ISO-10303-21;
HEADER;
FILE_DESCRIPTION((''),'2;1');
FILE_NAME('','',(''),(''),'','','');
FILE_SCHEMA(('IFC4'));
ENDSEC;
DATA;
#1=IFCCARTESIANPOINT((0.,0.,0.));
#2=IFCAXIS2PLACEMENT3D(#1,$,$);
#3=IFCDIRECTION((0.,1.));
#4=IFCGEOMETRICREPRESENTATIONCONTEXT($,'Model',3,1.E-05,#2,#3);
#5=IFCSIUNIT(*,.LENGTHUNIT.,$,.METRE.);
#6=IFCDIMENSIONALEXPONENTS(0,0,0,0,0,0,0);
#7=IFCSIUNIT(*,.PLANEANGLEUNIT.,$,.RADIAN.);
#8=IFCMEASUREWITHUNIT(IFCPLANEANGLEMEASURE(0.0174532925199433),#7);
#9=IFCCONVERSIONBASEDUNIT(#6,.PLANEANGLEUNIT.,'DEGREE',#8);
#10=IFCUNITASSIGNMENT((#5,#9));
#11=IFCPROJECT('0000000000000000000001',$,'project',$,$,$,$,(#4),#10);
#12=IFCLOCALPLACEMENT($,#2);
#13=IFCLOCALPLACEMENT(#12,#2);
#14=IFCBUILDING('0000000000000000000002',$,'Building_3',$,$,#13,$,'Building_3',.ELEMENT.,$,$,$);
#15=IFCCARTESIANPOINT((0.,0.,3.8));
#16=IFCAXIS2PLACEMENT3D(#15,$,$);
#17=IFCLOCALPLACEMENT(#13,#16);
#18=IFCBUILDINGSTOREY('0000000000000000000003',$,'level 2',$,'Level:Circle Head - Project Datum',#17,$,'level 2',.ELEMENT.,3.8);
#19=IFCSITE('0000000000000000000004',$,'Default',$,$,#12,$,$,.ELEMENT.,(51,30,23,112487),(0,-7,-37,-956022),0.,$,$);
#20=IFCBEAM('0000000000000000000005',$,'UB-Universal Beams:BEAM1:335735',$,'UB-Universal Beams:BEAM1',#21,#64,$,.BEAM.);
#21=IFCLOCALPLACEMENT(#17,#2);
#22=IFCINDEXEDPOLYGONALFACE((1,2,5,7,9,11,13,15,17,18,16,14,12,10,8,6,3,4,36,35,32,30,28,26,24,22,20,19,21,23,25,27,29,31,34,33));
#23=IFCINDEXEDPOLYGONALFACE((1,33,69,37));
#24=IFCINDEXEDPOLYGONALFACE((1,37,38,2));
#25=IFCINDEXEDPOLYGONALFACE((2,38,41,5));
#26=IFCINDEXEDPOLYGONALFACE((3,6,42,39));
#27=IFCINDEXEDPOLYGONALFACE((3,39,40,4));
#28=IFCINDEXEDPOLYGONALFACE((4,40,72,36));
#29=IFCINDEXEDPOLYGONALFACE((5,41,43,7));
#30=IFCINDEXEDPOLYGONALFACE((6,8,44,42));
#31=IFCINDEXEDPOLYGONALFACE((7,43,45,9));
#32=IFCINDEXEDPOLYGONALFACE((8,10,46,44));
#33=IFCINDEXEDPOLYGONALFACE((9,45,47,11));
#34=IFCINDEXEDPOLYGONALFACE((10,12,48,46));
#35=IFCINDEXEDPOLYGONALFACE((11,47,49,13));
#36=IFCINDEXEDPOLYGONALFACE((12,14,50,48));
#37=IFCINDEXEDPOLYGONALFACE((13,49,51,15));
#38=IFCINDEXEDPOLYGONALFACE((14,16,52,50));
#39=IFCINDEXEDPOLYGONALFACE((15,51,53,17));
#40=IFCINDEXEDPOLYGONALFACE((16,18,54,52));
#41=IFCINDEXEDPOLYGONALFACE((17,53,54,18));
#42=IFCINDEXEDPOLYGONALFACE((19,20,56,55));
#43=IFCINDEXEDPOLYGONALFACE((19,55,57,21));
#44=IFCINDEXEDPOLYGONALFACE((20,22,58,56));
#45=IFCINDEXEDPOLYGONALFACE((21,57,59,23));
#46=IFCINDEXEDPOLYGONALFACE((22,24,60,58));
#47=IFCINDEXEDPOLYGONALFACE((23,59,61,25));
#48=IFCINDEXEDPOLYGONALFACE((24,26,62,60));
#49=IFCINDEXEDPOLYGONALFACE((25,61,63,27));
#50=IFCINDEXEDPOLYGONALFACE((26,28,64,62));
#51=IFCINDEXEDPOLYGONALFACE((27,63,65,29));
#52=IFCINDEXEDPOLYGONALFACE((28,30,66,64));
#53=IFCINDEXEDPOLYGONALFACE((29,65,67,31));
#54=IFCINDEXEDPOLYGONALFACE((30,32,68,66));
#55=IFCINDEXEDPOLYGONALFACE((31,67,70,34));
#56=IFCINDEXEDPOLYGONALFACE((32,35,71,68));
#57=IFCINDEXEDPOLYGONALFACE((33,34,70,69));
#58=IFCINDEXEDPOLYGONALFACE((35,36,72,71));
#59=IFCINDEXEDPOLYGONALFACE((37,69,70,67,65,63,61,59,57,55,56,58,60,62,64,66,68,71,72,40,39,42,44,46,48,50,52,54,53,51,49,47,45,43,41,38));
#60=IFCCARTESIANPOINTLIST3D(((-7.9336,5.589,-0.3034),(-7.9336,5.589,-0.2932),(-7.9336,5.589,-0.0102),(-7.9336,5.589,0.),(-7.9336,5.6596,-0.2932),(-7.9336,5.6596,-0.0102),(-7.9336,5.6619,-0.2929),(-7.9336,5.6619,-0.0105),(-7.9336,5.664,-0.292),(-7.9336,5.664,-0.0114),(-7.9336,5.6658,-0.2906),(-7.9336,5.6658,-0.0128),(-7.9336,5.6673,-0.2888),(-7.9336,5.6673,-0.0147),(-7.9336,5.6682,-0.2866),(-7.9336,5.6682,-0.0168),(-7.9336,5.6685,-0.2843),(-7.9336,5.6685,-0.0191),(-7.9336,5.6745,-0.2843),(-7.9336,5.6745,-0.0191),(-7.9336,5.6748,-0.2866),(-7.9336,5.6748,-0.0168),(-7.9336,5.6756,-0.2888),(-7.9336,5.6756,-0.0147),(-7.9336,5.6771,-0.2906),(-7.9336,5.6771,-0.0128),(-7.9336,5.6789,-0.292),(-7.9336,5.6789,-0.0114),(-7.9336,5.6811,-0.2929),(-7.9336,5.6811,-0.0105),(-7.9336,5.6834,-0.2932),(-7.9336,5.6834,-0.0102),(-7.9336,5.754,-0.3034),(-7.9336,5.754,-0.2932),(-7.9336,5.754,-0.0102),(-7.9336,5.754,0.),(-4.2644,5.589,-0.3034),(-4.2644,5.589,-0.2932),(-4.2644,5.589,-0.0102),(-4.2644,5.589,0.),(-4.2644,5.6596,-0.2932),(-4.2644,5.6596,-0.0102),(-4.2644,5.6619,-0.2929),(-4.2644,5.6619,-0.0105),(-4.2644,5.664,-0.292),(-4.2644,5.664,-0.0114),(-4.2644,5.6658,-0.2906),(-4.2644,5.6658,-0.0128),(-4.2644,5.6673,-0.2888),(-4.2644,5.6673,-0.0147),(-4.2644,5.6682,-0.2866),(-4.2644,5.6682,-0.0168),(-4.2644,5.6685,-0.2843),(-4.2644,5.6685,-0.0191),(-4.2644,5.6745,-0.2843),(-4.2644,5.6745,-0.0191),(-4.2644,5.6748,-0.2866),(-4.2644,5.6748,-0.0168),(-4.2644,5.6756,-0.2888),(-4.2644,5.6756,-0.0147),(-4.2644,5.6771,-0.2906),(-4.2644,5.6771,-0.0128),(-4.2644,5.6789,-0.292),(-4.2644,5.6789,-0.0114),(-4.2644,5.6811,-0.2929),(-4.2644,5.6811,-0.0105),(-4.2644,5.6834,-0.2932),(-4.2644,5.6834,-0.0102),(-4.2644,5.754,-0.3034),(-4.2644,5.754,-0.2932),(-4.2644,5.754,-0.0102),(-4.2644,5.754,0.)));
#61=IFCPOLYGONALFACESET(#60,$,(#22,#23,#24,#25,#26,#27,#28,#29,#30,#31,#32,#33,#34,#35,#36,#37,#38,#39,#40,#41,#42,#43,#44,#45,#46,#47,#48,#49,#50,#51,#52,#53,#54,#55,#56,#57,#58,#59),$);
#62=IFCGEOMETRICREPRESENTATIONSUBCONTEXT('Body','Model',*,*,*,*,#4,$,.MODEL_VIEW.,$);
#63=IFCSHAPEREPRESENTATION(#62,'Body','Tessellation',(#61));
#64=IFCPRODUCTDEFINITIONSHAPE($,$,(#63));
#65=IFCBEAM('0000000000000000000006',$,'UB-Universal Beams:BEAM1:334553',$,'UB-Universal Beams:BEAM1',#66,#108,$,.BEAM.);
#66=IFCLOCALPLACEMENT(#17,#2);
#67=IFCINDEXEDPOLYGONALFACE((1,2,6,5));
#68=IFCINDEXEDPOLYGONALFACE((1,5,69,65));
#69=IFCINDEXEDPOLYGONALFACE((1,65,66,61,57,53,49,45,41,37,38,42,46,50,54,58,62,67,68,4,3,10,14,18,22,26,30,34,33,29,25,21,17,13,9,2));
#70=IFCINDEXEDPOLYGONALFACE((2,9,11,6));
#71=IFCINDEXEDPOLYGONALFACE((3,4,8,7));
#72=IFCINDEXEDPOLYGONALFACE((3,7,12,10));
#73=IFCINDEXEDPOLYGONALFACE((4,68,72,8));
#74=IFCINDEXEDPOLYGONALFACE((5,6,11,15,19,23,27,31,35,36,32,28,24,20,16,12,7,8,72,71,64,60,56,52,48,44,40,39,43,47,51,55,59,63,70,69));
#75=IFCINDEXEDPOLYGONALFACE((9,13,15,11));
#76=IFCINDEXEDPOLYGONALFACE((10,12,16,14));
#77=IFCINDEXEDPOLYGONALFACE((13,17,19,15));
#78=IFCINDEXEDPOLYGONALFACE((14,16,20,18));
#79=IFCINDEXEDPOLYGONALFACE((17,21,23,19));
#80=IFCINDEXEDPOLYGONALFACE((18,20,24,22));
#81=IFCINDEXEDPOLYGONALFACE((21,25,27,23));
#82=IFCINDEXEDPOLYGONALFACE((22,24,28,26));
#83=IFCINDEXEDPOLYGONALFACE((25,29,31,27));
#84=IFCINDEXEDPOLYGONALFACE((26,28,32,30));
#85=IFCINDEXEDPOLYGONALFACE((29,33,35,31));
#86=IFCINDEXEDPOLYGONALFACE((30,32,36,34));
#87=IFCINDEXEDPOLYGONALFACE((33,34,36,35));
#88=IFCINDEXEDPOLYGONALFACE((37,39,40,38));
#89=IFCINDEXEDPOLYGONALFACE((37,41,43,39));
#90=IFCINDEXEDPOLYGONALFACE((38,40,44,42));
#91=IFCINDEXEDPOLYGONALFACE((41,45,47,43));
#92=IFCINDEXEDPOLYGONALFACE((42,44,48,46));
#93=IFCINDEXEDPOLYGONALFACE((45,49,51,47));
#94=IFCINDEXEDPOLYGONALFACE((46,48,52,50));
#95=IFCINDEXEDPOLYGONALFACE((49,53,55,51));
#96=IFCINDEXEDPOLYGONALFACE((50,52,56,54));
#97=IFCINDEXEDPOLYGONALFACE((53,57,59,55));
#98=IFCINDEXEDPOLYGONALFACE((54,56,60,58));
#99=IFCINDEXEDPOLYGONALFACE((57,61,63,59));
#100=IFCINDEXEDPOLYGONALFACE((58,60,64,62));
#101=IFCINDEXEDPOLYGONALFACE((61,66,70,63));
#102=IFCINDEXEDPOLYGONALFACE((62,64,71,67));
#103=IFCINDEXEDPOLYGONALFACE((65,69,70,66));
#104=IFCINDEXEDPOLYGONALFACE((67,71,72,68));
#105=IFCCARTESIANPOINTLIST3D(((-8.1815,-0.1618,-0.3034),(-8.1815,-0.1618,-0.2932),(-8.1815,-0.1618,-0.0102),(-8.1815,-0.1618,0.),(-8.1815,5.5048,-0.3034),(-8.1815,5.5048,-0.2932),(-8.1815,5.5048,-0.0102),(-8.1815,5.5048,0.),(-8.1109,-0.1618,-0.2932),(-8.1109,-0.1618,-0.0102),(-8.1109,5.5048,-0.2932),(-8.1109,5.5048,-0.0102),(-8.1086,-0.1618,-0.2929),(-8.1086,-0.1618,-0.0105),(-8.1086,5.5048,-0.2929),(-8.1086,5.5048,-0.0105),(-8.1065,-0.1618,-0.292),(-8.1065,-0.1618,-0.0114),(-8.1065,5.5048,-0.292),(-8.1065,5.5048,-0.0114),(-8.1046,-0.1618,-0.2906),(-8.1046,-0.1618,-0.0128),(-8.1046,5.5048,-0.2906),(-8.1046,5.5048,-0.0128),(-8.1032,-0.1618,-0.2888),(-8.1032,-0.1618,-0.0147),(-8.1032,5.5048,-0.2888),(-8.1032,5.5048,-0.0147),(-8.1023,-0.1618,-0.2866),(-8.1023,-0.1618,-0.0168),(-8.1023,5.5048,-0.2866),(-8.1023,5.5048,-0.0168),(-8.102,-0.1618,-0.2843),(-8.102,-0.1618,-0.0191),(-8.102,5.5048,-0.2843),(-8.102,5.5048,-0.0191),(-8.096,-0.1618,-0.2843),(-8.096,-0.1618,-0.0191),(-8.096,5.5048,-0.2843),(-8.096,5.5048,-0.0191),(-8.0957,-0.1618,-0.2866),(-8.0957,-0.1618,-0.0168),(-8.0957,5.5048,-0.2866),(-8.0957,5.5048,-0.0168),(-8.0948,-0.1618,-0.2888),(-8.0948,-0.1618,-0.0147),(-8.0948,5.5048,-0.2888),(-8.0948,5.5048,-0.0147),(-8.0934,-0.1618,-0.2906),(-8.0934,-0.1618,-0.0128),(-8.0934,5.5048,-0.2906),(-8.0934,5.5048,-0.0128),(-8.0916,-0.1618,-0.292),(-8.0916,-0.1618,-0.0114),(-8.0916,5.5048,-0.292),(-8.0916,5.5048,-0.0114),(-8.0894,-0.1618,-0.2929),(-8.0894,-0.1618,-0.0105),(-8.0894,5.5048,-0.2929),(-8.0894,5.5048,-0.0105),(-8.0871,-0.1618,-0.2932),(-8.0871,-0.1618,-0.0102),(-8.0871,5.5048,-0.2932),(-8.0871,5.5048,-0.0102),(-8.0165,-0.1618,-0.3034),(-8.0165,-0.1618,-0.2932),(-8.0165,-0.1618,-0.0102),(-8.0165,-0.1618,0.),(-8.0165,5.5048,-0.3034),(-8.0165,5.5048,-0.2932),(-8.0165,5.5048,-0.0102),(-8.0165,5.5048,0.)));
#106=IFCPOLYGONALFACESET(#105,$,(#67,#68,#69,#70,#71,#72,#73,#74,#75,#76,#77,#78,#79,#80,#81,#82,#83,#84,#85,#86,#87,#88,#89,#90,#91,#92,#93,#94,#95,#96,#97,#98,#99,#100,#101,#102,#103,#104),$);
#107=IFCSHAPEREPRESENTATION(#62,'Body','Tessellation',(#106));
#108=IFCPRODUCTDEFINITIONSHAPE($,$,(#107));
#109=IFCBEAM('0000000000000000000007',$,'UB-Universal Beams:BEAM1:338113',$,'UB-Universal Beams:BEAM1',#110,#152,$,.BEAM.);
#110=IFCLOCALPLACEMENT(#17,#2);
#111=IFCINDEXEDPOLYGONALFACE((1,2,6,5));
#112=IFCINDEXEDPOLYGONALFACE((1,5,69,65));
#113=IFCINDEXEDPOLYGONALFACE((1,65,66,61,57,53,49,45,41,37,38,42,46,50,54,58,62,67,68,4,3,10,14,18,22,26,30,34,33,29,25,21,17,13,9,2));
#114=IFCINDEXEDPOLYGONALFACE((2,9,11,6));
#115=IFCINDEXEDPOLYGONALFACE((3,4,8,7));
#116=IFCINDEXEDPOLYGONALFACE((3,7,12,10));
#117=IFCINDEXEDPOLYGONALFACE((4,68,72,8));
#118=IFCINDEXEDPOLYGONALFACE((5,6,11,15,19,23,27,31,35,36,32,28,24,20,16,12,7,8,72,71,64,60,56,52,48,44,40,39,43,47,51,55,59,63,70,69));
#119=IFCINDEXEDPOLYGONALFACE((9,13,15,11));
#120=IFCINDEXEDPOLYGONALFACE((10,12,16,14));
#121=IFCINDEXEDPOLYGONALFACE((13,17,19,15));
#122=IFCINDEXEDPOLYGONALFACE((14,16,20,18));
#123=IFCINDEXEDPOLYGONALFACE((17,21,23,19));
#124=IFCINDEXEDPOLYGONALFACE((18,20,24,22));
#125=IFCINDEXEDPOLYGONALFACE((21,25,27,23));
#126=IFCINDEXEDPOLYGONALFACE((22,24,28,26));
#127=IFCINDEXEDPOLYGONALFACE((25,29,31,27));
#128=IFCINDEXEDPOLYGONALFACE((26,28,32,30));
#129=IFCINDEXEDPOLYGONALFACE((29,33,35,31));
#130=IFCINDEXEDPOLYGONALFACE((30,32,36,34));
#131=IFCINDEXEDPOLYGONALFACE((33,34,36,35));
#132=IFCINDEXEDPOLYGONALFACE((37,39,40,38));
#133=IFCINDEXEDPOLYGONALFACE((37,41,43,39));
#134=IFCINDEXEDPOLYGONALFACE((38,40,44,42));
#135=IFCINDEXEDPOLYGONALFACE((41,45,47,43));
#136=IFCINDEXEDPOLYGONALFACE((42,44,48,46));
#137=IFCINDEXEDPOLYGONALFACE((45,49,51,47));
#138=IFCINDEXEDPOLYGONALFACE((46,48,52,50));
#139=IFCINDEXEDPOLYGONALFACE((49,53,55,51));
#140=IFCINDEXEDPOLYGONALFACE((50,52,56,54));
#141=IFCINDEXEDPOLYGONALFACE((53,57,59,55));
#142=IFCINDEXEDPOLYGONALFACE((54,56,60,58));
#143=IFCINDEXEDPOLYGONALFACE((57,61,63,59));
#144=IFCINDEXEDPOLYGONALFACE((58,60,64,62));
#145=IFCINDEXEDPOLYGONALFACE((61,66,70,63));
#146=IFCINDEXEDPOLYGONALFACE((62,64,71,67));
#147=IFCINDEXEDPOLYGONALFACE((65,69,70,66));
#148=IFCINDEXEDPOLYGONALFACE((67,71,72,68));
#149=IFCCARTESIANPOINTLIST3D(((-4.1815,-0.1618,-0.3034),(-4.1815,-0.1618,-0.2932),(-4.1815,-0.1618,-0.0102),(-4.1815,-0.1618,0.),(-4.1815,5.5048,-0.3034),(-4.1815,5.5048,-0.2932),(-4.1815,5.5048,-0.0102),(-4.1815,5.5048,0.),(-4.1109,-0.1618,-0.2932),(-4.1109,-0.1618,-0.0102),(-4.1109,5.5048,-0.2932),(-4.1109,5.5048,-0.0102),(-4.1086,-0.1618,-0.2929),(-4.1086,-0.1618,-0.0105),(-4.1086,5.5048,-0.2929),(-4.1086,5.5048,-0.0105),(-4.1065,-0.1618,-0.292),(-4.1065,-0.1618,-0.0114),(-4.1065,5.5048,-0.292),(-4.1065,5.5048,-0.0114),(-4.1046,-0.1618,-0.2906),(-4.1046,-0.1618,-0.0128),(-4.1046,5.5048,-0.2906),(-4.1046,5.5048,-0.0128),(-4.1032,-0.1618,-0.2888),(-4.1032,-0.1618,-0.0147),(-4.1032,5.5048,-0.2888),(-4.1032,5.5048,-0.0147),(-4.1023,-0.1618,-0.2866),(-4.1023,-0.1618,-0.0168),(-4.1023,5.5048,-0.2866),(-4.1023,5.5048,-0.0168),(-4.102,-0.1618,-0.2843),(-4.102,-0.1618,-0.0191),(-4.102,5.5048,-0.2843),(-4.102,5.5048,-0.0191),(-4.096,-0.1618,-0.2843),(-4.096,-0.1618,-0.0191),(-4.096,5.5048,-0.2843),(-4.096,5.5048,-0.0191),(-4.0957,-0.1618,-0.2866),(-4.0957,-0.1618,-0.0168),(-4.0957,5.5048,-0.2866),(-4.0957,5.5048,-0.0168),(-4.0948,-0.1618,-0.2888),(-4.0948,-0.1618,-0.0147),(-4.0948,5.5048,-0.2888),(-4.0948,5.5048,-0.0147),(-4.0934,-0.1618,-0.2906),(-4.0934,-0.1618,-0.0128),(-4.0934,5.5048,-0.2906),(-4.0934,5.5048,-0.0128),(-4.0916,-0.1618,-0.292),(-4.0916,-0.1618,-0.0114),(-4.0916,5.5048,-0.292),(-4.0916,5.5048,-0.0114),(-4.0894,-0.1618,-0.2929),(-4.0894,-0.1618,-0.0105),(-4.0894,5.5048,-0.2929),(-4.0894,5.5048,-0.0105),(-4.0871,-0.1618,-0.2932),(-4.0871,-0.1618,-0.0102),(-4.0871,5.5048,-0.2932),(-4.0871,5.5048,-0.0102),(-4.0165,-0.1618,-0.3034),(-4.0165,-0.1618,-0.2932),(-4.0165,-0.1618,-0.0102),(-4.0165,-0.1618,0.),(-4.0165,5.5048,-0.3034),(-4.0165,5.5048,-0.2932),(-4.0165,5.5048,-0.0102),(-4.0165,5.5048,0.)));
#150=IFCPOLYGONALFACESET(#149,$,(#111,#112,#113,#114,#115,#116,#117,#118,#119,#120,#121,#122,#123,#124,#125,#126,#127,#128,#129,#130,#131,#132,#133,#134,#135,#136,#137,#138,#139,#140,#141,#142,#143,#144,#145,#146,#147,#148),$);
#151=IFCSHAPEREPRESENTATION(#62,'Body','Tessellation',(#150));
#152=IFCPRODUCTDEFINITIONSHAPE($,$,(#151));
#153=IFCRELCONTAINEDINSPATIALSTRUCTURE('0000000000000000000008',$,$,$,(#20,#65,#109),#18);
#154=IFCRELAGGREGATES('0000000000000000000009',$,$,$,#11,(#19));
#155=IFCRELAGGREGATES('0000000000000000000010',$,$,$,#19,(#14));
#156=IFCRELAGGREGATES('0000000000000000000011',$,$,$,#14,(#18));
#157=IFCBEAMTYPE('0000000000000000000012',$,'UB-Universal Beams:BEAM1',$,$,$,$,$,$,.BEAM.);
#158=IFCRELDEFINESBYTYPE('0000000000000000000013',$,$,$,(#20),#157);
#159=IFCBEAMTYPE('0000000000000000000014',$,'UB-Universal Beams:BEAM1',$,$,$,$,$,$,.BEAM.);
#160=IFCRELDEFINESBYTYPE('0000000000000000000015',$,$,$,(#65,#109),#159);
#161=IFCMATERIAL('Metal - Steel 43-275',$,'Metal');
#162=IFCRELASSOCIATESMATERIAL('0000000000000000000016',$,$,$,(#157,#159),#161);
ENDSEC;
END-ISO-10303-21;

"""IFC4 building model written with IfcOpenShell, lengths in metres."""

from ifc_helpers import new_model, entity, si_unit, converted_unit, direction, frame, frame_2d, origin, place, context, subcontext, project, spatial, polyline, circle_curve, parameter, trimmed, segment, composite_curve, outline, extrude, source, transform, mapped, material, material_profile, profile_set, type_object, type_shapes, element, save


model = new_model("IFC4")

# Units and contexts
model_context = context("Model", 3, precision=1e-05, world=origin(), true_north=direction((0.0, 1.0)))
body_context = subcontext(model_context, "Body", "Model", "MODEL_VIEW")
ifc_project = project(units=[si_unit("LENGTHUNIT", "METRE"), converted_unit("PLANEANGLEUNIT", "DEGREE", entity("IfcPlaneAngleMeasure", 0.0174532925199433), si_unit("PLANEANGLEUNIT", "RADIAN"), dimensions=[0, 0, 0, 0, 0, 0, 0])], contexts=[model_context])

# Site, building, storey
site_placement = place(None, origin())
site = spatial("IfcSite", under=ifc_project, at=site_placement, Name="Default", CompositionType="ELEMENT", RefLatitude=(51, 30, 23, 112487), RefLongitude=(0, -7, -37, -956022), RefElevation=0.0)
building_placement = place(site_placement, origin())
building = spatial("IfcBuilding", under=site, at=building_placement, Name="Building_3", LongName="Building_3", CompositionType="ELEMENT")
storey_placement = place(building_placement, frame((0.0, 0.0, 3.8)))
storey = spatial("IfcBuildingStorey", under=building, at=storey_placement, Name="level 2", ObjectType="Level:Circle Head - Project Datum", LongName="level 2", CompositionType="ELEMENT", Elevation=3.8)

# Shared definitions
ifc_material_1 = material(Name="Metal - Steel 43-275", Category="Metal")

# Beams
ifc_material_profile_1 = material_profile(ifc_material_1, outline(composite_curve([segment(polyline([(-0.0825, -0.1415), (-0.0825, -0.1517)]), True, "CONTINUOUS"), segment(polyline([(-0.0825, -0.1517), (0.0825, -0.1517)]), True, "CONTINUOUS"), segment(polyline([(0.0825, -0.1517), (0.0825, -0.1415)]), True, "CONTINUOUS"), segment(polyline([(0.0825, -0.1415), (0.0119, -0.1415)]), True, "CONTINUOUS"), segment(trimmed(circle_curve(frame_2d((0.0119, -0.1326), x_axis=(1.0, 0.0)), 0.0089), [parameter(180.0)], [parameter(270.0)], True, "PARAMETER"), False, "CONTINUOUS"), segment(polyline([(0.003, -0.1326), (0.003, 0.1326)]), True, "CONTINUOUS"), segment(trimmed(circle_curve(frame_2d((0.0119, 0.1326), x_axis=(1.0, 0.0)), 0.0089), [parameter(90.0)], [parameter(180.0)], True, "PARAMETER"), False, "CONTINUOUS"), segment(polyline([(0.0119, 0.1415), (0.0825, 0.1415)]), True, "CONTINUOUS"), segment(polyline([(0.0825, 0.1415), (0.0825, 0.1517)]), True, "CONTINUOUS"), segment(polyline([(0.0825, 0.1517), (-0.0825, 0.1517)]), True, "CONTINUOUS"), segment(polyline([(-0.0825, 0.1517), (-0.0825, 0.1415)]), True, "CONTINUOUS"), segment(polyline([(-0.0825, 0.1415), (-0.0119, 0.1415)]), True, "CONTINUOUS"), segment(trimmed(circle_curve(frame_2d((-0.0119, 0.1326), x_axis=(1.0, 0.0)), 0.0089), [parameter(360.0)], [parameter(90.0)], True, "PARAMETER"), False, "CONTINUOUS"), segment(polyline([(-0.003, 0.1326), (-0.003, -0.1326)]), True, "CONTINUOUS"), segment(trimmed(circle_curve(frame_2d((-0.0119, -0.1326), x_axis=(1.0, 0.0)), 0.0089), [parameter(270.0)], [parameter(360.0)], True, "PARAMETER"), False, "CONTINUOUS"), segment(polyline([(-0.0119, -0.1415), (-0.0825, -0.1415)]), True, "CONTINUOUS")], self_intersect=False)), Name="BEAM1")
ifc_profile_set_1 = profile_set([ifc_material_profile_1], Name="BEAM1")
beam_type_1 = type_object("IfcBeamType", Name="UB-Universal Beams:BEAM1", PredefinedType="BEAM", material=ifc_profile_set_1)
shared_shape_1 = source(origin(), body_context, "Body", "SweptSolid", [
    extrude(outline(composite_curve([segment(polyline([(-0.0825, -0.1415), (-0.0825, -0.1517)]), True, "CONTINUOUS"), segment(polyline([(-0.0825, -0.1517), (0.0825, -0.1517)]), True, "CONTINUOUS"), segment(polyline([(0.0825, -0.1517), (0.0825, -0.1415)]), True, "CONTINUOUS"), segment(polyline([(0.0825, -0.1415), (0.0119, -0.1415)]), True, "CONTINUOUS"), segment(trimmed(circle_curve(frame_2d((0.0119, -0.1326), x_axis=(0.0, -1.0)), 0.0089), [parameter(270.0)], [parameter(360.0)], True, "PARAMETER"), False, "CONTINUOUS"), segment(polyline([(0.003, -0.1326), (0.003, 0.1326)]), True, "CONTINUOUS"), segment(trimmed(circle_curve(frame_2d((0.0119, 0.1326), x_axis=(-1.0, 0.0)), 0.0089), [parameter(270.0)], [parameter(360.0)], True, "PARAMETER"), False, "CONTINUOUS"), segment(polyline([(0.0119, 0.1415), (0.0825, 0.1415)]), True, "CONTINUOUS"), segment(polyline([(0.0825, 0.1415), (0.0825, 0.1517)]), True, "CONTINUOUS"), segment(polyline([(0.0825, 0.1517), (-0.0825, 0.1517)]), True, "CONTINUOUS"), segment(polyline([(-0.0825, 0.1517), (-0.0825, 0.1415)]), True, "CONTINUOUS"), segment(polyline([(-0.0825, 0.1415), (-0.0119, 0.1415)]), True, "CONTINUOUS"), segment(trimmed(circle_curve(frame_2d((-0.0119, 0.1326), x_axis=(0.0, 1.0)), 0.0089), [parameter(270.0)], [parameter(360.0)], True, "PARAMETER"), False, "CONTINUOUS"), segment(polyline([(-0.003, 0.1326), (-0.003, -0.1326)]), True, "CONTINUOUS"), segment(trimmed(circle_curve(frame_2d((-0.0119, -0.1326), x_axis=(1.0, 0.0)), 0.0089), [parameter(270.0)], [parameter(0.0)], True, "PARAMETER"), False, "CONTINUOUS"), segment(polyline([(-0.0119, -0.1415), (-0.0825, -0.1415)]), True, "CONTINUOUS")], self_intersect=False)), frame((-1.8346, 0.0, 0.0), z_axis=(-1.0, 0.0, 0.0), x_axis=(0.0, -1.0, 0.0)), (0.0, 0.0, -1.0), 3.6692),
])
type_shapes(beam_type_1, [shared_shape_1])
beam_1_placement = place(storey_placement, frame((-6.099, 5.6715, -0.1517)))
element("IfcBeam", 1, at=beam_1_placement, inside=storey, type_object=beam_type_1, Name="UB-Universal Beams:BEAM1:335735", ObjectType="UB-Universal Beams:BEAM1", PredefinedType="BEAM", context=body_context, shape_type="MappedRepresentation", body=[
    mapped(shared_shape_1, transform((0.0, 0.0, 0.0), scale=1.0)),
])
beam_type_2 = type_object("IfcBeamType", Name="UB-Universal Beams:BEAM1", PredefinedType="BEAM", material=ifc_profile_set_1)
shared_shape_2 = source(origin(), body_context, "Body", "SweptSolid", [
    extrude(outline(composite_curve([segment(polyline([(-0.0825, -0.1415), (-0.0825, -0.1517)]), True, "CONTINUOUS"), segment(polyline([(-0.0825, -0.1517), (0.0825, -0.1517)]), True, "CONTINUOUS"), segment(polyline([(0.0825, -0.1517), (0.0825, -0.1415)]), True, "CONTINUOUS"), segment(polyline([(0.0825, -0.1415), (0.0119, -0.1415)]), True, "CONTINUOUS"), segment(trimmed(circle_curve(frame_2d((0.0119, -0.1326), x_axis=(1.0, 0.0)), 0.0089), [parameter(180.0)], [parameter(270.0)], True, "PARAMETER"), False, "CONTINUOUS"), segment(polyline([(0.003, -0.1326), (0.003, 0.1326)]), True, "CONTINUOUS"), segment(trimmed(circle_curve(frame_2d((0.0119, 0.1326), x_axis=(1.0, 0.0)), 0.0089), [parameter(90.0)], [parameter(180.0)], True, "PARAMETER"), False, "CONTINUOUS"), segment(polyline([(0.0119, 0.1415), (0.0825, 0.1415)]), True, "CONTINUOUS"), segment(polyline([(0.0825, 0.1415), (0.0825, 0.1517)]), True, "CONTINUOUS"), segment(polyline([(0.0825, 0.1517), (-0.0825, 0.1517)]), True, "CONTINUOUS"), segment(polyline([(-0.0825, 0.1517), (-0.0825, 0.1415)]), True, "CONTINUOUS"), segment(polyline([(-0.0825, 0.1415), (-0.0119, 0.1415)]), True, "CONTINUOUS"), segment(trimmed(circle_curve(frame_2d((-0.0119, 0.1326), x_axis=(1.0, 0.0)), 0.0089), [parameter(360.0)], [parameter(90.0)], True, "PARAMETER"), False, "CONTINUOUS"), segment(polyline([(-0.003, 0.1326), (-0.003, -0.1326)]), True, "CONTINUOUS"), segment(trimmed(circle_curve(frame_2d((-0.0119, -0.1326), x_axis=(1.0, 0.0)), 0.0089), [parameter(270.0)], [parameter(360.0)], True, "PARAMETER"), False, "CONTINUOUS"), segment(polyline([(-0.0119, -0.1415), (-0.0825, -0.1415)]), True, "CONTINUOUS")], self_intersect=False)), frame((-2.8333, 0.0, 0.0), z_axis=(-1.0, 0.0, 0.0), x_axis=(0.0, -1.0, 0.0)), (0.0, 0.0, -1.0), 5.6666),
])
type_shapes(beam_type_2, [shared_shape_2])
for number, where, z_axis, x_axis, name in (
    (2, (-8.099, 2.6715, -0.1517), (0.0, 0.0, 1.0), (0.0, -1.0, 0.0), "UB-Universal Beams:BEAM1:334553"),
    (3, (-4.099, 2.6715, -0.1517), (0.0, 0.0, 1.0), (0.0, -1.0, 0.0), "UB-Universal Beams:BEAM1:338113"),
):
    element("IfcBeam", number, at=place(storey_placement, frame(where, z_axis=z_axis, x_axis=x_axis)), inside=storey, type_object=beam_type_2, Name=name, ObjectType="UB-Universal Beams:BEAM1", PredefinedType="BEAM", context=body_context, shape_type="MappedRepresentation", body=[
        mapped(shared_shape_2, transform((0.0, 0.0, 0.0), scale=1.0)),
    ])

save(model, "model.ifc")
